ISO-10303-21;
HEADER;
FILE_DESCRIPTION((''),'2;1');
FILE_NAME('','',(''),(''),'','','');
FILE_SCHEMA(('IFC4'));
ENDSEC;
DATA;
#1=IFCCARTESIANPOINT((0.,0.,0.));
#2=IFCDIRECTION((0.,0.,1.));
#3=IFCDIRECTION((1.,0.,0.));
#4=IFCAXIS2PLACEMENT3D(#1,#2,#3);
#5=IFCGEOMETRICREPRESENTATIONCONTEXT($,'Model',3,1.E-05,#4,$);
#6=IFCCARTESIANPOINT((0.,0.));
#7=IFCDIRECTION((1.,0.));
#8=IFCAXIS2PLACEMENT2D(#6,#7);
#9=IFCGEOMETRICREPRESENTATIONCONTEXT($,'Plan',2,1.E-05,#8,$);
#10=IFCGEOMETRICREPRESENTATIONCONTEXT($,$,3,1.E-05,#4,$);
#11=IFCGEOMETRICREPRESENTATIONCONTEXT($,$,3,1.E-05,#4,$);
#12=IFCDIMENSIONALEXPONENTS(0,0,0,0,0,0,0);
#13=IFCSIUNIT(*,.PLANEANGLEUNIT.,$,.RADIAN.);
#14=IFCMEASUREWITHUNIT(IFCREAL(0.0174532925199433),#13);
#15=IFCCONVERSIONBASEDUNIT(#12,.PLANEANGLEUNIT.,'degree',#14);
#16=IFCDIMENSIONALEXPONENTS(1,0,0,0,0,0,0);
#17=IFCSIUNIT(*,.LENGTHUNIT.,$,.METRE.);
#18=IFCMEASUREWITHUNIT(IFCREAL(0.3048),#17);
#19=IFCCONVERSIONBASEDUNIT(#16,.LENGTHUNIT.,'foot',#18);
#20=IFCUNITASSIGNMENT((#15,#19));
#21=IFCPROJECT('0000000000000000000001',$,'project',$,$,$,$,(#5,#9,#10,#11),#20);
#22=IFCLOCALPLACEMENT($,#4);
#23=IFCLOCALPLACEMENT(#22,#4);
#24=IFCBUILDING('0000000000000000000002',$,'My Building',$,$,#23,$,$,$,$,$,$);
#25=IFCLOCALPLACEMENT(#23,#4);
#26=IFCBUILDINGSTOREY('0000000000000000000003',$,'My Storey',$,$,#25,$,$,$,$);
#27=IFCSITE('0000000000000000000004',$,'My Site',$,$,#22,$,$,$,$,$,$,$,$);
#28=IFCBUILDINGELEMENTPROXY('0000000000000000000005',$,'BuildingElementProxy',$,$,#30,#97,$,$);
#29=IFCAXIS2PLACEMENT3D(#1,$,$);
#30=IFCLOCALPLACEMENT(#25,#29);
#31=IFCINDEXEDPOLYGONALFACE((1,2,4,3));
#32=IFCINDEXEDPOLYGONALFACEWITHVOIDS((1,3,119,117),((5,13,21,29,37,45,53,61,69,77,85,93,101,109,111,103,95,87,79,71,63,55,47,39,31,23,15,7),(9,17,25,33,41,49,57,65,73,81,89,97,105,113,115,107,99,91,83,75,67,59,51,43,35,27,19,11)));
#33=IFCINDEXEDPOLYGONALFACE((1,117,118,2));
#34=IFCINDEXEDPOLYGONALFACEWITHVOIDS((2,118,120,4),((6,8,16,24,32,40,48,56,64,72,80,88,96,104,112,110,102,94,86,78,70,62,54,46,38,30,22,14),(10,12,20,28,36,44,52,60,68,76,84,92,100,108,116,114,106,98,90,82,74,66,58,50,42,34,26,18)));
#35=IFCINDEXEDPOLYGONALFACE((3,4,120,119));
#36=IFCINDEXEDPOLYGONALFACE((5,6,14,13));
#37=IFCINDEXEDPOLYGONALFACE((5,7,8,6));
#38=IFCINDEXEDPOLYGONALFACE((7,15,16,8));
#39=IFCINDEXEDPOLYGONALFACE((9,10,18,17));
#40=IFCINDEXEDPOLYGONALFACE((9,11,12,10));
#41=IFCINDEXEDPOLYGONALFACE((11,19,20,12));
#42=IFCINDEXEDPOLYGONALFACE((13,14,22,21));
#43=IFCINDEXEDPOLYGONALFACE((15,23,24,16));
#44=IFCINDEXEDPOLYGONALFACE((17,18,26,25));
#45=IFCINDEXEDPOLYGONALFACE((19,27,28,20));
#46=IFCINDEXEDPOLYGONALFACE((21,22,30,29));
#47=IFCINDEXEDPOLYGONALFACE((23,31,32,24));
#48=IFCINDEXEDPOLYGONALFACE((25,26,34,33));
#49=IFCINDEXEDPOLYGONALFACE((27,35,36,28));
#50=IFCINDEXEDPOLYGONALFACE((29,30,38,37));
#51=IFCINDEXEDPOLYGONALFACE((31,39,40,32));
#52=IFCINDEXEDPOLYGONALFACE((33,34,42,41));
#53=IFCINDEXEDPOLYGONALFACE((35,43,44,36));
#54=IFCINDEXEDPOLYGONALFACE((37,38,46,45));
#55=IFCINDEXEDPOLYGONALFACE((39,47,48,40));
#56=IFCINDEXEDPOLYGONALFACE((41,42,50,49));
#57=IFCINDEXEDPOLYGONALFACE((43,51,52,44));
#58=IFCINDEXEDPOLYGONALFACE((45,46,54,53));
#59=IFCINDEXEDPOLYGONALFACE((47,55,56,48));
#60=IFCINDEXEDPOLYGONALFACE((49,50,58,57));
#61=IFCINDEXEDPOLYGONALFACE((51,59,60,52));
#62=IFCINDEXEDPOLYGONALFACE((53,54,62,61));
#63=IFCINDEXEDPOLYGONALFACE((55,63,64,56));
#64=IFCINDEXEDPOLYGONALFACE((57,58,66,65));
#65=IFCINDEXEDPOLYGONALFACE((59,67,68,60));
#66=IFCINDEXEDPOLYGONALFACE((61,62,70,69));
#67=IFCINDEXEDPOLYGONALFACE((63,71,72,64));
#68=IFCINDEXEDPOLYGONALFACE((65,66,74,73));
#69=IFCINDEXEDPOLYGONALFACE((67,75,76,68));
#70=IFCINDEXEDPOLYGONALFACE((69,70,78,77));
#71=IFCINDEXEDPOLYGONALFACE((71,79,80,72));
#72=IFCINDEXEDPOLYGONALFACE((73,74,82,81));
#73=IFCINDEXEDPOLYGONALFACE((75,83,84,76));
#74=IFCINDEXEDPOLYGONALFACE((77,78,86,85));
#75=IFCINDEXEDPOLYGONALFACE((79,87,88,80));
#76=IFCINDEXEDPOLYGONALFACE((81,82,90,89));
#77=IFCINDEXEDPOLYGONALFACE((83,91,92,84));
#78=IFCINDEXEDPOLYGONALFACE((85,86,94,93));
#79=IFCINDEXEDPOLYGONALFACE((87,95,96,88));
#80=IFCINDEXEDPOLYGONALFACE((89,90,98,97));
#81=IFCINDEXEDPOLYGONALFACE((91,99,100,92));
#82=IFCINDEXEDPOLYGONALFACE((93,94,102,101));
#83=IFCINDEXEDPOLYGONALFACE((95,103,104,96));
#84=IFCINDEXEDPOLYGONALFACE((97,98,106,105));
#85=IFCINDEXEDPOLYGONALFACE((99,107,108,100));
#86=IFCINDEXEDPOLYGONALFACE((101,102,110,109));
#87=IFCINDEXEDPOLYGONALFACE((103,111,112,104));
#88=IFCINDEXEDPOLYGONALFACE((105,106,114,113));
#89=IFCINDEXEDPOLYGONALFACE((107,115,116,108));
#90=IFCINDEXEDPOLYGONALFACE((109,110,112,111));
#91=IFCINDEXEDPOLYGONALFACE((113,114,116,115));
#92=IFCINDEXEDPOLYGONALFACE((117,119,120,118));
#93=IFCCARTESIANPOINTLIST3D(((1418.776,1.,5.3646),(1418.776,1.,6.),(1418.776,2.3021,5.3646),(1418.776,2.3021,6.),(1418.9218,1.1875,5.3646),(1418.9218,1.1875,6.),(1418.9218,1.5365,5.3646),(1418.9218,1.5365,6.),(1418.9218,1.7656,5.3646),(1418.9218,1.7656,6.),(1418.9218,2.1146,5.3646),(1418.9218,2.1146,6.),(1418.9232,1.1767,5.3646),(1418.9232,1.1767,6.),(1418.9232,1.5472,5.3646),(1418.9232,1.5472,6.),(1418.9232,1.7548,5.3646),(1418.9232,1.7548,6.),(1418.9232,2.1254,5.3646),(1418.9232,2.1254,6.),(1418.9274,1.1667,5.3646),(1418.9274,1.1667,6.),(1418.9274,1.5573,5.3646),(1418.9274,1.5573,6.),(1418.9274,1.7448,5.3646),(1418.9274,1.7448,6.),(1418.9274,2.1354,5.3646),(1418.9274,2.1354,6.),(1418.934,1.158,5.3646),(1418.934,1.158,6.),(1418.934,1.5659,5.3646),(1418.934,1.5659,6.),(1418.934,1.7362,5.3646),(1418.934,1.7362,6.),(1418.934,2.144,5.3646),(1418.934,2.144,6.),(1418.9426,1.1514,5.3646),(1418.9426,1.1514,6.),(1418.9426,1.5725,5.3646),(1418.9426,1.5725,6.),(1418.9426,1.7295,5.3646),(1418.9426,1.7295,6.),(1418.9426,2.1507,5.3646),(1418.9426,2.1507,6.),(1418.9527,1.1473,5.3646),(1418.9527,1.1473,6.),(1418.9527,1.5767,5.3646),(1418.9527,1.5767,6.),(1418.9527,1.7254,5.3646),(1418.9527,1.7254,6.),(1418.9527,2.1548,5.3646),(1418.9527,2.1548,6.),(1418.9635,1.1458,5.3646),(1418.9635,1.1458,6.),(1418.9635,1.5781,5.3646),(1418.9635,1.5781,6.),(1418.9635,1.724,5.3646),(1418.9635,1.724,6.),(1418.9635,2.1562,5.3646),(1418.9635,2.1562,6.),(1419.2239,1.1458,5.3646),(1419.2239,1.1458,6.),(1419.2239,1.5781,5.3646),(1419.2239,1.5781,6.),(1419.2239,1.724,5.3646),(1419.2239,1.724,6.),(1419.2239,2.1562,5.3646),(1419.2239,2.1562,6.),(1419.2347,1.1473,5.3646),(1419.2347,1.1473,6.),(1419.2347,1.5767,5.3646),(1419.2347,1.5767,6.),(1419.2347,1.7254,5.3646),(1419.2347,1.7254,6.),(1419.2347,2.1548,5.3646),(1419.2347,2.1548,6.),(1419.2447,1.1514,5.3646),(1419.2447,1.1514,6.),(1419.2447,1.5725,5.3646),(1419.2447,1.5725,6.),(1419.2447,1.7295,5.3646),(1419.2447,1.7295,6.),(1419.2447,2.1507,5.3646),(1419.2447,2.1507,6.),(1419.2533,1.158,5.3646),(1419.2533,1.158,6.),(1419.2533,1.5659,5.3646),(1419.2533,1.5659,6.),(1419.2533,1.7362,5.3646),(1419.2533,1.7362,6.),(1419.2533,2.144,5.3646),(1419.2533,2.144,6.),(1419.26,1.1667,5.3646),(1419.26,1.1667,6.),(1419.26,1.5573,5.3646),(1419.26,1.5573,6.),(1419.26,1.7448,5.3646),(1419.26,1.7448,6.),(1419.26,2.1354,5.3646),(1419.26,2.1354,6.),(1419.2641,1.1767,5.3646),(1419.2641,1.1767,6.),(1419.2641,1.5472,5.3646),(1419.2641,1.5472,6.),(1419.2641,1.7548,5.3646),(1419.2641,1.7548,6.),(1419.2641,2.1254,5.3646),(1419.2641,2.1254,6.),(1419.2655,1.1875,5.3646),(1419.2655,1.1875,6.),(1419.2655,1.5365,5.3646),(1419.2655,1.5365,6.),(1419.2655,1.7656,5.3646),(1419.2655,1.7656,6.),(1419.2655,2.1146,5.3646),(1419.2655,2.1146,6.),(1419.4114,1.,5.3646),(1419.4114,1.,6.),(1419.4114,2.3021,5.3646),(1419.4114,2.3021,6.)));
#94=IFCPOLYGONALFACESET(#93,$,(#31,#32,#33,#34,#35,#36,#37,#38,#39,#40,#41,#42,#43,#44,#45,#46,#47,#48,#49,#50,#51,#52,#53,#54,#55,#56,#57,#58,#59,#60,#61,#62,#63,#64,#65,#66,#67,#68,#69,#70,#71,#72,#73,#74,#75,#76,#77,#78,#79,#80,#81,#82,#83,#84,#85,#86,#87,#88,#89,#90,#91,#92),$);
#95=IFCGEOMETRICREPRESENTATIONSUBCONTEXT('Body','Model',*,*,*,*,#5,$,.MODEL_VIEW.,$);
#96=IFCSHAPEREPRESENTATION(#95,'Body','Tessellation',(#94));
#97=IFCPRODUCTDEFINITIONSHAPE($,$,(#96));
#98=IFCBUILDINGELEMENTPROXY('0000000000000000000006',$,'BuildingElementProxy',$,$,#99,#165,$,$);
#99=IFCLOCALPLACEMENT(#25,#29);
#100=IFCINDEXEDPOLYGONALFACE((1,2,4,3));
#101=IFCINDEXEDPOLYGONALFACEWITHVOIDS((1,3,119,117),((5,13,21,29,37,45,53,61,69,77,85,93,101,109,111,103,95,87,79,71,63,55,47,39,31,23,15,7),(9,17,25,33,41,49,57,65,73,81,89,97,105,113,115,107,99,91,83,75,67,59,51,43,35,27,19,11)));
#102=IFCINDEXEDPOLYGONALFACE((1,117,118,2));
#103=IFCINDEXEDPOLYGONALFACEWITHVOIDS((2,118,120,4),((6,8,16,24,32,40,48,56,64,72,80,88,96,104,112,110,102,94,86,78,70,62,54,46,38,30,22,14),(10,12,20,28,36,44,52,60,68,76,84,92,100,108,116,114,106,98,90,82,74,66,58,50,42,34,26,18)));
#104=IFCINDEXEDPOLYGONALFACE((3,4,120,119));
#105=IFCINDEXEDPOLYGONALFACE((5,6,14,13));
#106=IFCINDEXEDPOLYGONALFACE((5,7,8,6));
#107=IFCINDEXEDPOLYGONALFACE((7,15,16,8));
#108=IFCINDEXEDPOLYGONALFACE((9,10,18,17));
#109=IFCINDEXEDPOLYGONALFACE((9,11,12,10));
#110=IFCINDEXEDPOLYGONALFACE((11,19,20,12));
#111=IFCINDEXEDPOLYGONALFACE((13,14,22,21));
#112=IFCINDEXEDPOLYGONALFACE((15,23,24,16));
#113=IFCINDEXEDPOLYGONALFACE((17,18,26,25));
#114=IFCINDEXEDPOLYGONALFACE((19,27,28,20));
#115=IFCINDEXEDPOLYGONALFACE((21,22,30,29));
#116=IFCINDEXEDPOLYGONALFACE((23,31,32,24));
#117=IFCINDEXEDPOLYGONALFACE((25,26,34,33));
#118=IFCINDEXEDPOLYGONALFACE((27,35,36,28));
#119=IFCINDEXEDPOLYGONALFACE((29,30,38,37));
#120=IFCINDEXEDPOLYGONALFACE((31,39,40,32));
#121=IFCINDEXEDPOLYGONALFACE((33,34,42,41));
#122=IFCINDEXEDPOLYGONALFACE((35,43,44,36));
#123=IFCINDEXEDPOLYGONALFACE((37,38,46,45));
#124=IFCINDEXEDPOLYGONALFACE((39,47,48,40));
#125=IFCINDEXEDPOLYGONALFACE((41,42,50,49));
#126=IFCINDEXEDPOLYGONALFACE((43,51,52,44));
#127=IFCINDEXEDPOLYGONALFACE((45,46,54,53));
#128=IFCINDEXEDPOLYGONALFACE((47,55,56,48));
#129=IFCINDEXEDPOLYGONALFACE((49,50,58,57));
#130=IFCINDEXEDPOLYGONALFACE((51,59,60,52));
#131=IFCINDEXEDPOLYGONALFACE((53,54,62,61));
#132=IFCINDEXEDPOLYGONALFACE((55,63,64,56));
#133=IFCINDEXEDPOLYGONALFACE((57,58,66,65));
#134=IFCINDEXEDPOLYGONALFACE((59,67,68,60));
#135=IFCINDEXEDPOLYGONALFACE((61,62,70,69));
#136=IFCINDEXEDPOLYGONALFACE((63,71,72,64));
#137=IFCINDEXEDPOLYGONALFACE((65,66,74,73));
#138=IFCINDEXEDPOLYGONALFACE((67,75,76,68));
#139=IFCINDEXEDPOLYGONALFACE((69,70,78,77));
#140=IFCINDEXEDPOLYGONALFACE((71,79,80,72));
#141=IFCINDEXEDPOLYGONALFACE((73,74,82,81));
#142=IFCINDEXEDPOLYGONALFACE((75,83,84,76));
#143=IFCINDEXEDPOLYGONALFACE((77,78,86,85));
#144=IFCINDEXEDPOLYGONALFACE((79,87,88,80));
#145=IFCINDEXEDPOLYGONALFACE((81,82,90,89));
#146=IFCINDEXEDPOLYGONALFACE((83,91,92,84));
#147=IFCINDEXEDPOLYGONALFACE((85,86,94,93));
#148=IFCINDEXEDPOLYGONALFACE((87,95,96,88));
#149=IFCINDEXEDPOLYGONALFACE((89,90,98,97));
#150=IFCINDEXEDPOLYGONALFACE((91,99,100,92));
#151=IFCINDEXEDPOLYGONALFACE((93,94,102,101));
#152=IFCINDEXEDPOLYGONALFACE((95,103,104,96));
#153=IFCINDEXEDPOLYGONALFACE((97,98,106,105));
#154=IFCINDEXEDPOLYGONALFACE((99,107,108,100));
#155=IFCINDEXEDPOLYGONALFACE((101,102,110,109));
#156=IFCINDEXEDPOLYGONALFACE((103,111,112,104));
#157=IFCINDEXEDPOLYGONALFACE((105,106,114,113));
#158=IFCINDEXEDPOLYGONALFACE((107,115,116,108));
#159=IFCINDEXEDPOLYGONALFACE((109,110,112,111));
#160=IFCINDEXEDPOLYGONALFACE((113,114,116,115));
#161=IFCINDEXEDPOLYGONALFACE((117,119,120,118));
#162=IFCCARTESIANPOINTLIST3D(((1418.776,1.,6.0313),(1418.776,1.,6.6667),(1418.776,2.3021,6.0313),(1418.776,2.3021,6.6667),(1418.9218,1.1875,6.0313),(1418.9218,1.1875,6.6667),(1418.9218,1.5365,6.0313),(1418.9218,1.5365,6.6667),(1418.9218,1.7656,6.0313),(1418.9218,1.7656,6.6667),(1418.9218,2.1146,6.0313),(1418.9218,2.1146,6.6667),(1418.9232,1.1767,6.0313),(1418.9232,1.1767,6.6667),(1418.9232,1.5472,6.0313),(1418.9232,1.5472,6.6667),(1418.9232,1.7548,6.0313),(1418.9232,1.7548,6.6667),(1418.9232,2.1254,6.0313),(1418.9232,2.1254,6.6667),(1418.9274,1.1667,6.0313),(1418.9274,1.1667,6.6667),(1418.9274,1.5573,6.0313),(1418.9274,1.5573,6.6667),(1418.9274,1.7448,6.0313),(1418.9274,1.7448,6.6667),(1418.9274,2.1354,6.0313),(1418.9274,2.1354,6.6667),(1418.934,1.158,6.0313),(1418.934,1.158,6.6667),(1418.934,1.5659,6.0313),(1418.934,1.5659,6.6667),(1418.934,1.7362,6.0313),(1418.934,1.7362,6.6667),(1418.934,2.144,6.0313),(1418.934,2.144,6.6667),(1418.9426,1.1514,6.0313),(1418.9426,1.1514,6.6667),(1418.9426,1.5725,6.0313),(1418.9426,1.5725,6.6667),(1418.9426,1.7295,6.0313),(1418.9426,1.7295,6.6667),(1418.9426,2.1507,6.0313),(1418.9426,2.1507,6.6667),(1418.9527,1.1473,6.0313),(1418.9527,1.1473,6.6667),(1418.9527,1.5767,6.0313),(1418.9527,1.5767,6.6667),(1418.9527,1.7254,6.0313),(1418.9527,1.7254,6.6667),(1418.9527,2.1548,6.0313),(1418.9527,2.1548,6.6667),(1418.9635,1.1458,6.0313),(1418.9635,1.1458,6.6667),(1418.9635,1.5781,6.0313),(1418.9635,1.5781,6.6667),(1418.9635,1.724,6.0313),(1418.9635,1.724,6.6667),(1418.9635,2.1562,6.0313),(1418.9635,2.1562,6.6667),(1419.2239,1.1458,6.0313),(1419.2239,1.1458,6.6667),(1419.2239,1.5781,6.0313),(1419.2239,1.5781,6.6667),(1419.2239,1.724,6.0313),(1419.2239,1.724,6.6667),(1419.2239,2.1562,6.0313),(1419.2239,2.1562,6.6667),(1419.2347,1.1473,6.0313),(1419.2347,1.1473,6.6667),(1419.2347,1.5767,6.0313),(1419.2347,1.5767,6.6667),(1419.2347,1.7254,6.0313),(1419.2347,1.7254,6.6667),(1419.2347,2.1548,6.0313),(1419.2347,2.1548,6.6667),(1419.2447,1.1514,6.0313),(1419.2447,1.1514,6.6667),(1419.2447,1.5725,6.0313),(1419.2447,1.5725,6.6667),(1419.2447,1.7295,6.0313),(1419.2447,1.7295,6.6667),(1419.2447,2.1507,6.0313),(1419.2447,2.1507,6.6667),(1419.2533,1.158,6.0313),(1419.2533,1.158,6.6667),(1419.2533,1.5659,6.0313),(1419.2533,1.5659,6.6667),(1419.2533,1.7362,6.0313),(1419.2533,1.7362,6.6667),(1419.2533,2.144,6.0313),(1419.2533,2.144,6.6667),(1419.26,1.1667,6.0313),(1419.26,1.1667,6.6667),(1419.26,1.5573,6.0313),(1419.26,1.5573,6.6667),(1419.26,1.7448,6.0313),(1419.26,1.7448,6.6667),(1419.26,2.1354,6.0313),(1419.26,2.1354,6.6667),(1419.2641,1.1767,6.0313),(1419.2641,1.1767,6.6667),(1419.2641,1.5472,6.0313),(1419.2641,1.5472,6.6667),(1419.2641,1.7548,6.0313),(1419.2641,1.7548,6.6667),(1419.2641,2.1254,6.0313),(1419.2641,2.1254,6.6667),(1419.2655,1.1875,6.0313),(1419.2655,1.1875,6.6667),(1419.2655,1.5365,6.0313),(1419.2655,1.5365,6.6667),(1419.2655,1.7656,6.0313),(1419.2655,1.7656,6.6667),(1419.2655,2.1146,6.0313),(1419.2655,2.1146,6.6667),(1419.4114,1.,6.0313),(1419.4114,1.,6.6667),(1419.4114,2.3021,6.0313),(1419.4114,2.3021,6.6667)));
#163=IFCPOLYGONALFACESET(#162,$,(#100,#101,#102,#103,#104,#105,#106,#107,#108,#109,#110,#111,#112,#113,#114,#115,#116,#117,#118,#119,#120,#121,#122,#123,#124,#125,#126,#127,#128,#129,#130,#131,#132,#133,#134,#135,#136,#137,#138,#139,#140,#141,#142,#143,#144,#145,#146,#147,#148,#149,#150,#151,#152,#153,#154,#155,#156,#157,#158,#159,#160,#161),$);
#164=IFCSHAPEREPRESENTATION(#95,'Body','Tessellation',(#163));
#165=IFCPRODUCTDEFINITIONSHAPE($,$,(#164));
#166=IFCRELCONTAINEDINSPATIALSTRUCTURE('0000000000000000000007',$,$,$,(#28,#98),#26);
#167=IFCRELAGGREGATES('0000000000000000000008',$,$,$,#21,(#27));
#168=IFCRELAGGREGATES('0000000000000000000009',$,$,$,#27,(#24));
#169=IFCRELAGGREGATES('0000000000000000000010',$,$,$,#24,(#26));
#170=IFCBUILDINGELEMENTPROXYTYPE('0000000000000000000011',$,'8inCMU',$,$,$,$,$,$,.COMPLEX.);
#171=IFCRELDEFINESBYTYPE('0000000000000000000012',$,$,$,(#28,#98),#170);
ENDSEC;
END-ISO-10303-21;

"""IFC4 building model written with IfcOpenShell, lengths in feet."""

from ifc_helpers import new_model, entity, si_unit, converted_unit, frame, origin_with_axes, origin_2d_with_axis, place, context, subcontext, project, spatial, line, indexed_curve, outline, extrude, source, transform, mapped, type_object, type_shapes, element, save


model = new_model("IFC4")

# Units and contexts
model_context_1 = context("Model", 3, precision=1e-05, world=origin_with_axes())
plan_context = context("Plan", 2, precision=1e-05, world=origin_2d_with_axis())
context_of_model_1 = context(None, 3, precision=1e-05, world=origin_with_axes())
context_of_model_2 = context(None, 3, precision=1e-05, world=origin_with_axes())
body_context_1 = subcontext(model_context_1, "Body", "Model", "MODEL_VIEW")
ifc_project = project(units=[converted_unit("PLANEANGLEUNIT", "degree", entity("IfcReal", 0.0174532925199433), si_unit("PLANEANGLEUNIT", "RADIAN"), dimensions=[0, 0, 0, 0, 0, 0, 0]), converted_unit("LENGTHUNIT", "foot", entity("IfcReal", 0.3048), si_unit("LENGTHUNIT", "METRE"), dimensions=[1, 0, 0, 0, 0, 0, 0])], contexts=[model_context_1, plan_context, context_of_model_1, context_of_model_2])

# Site, building, storey
site_placement = place(None, origin_with_axes())
site = spatial("IfcSite", under=ifc_project, at=site_placement, Name="My Site")
building_placement = place(site_placement, origin_with_axes())
building = spatial("IfcBuilding", under=site, at=building_placement, Name="My Building")
storey_placement = place(building_placement, origin_with_axes())
storey = spatial("IfcBuildingStorey", under=building, at=storey_placement, Name="My Storey")

# Building element proxies
building_element_proxy_type_1 = type_object("IfcBuildingElementProxyType", Name="8inCMU", PredefinedType="COMPLEX")
shared_shape_1 = source(origin_with_axes(), body_context_1, "Body", "SweptSolid", [
    extrude(outline(indexed_curve([(-0.3177, -0.651), (0.3177, -0.651), (0.3177, 0.651), (-0.3177, 0.651), (0.1719, -0.1146), (0.1719, -0.4635), (0.1705, -0.4743), (0.1663, -0.4844), (0.1597, -0.493), (0.151, -0.4996), (0.141, -0.5038), (0.1302, -0.5052), (-0.1302, -0.5052), (-0.141, -0.5038), (-0.151, -0.4996), (-0.1597, -0.493), (-0.1663, -0.4844), (-0.1705, -0.4743), (-0.1719, -0.4635), (-0.1719, -0.1146), (-0.1705, -0.1038), (-0.1663, -0.0938), (-0.1597, -0.0851), (-0.151, -0.0785), (-0.141, -0.0743), (-0.1302, -0.0729), (0.1302, -0.0729), (0.141, -0.0743), (0.151, -0.0785), (0.1597, -0.0851), (0.1663, -0.0938), (0.1705, -0.1038), (0.151, 0.0785), (0.141, 0.0743), (0.1302, 0.0729), (-0.1302, 0.0729), (-0.141, 0.0743), (-0.151, 0.0785), (-0.1597, 0.0851), (-0.1663, 0.0937), (-0.1705, 0.1038), (-0.1719, 0.1146), (-0.1719, 0.4635), (-0.1705, 0.4743), (-0.1663, 0.4844), (-0.1597, 0.493), (-0.151, 0.4996), (-0.141, 0.5038), (-0.1302, 0.5052), (0.1302, 0.5052), (0.141, 0.5038), (0.151, 0.4996), (0.1597, 0.493), (0.1663, 0.4844), (0.1705, 0.4743), (0.1719, 0.4635), (0.1719, 0.1146), (0.1705, 0.1038), (0.1663, 0.0937), (0.1597, 0.0851)], segments=[line(4, 3), line(3, 2), line(2, 1), line(1, 4)], self_intersect=False), holes=[indexed_curve([(-0.3177, -0.651), (0.3177, -0.651), (0.3177, 0.651), (-0.3177, 0.651), (0.1719, -0.1146), (0.1719, -0.4635), (0.1705, -0.4743), (0.1663, -0.4844), (0.1597, -0.493), (0.151, -0.4996), (0.141, -0.5038), (0.1302, -0.5052), (-0.1302, -0.5052), (-0.141, -0.5038), (-0.151, -0.4996), (-0.1597, -0.493), (-0.1663, -0.4844), (-0.1705, -0.4743), (-0.1719, -0.4635), (-0.1719, -0.1146), (-0.1705, -0.1038), (-0.1663, -0.0938), (-0.1597, -0.0851), (-0.151, -0.0785), (-0.141, -0.0743), (-0.1302, -0.0729), (0.1302, -0.0729), (0.141, -0.0743), (0.151, -0.0785), (0.1597, -0.0851), (0.1663, -0.0938), (0.1705, -0.1038), (0.151, 0.0785), (0.141, 0.0743), (0.1302, 0.0729), (-0.1302, 0.0729), (-0.141, 0.0743), (-0.151, 0.0785), (-0.1597, 0.0851), (-0.1663, 0.0937), (-0.1705, 0.1038), (-0.1719, 0.1146), (-0.1719, 0.4635), (-0.1705, 0.4743), (-0.1663, 0.4844), (-0.1597, 0.493), (-0.151, 0.4996), (-0.141, 0.5038), (-0.1302, 0.5052), (0.1302, 0.5052), (0.141, 0.5038), (0.151, 0.4996), (0.1597, 0.493), (0.1663, 0.4844), (0.1705, 0.4743), (0.1719, 0.4635), (0.1719, 0.1146), (0.1705, 0.1038), (0.1663, 0.0937), (0.1597, 0.0851)], segments=[line(20, 19), line(19, 18), line(18, 17), line(17, 16), line(16, 15), line(15, 14), line(14, 13), line(13, 12), line(12, 11), line(11, 10), line(10, 9), line(9, 8), line(8, 7), line(7, 6), line(6, 5), line(5, 32), line(32, 31), line(31, 30), line(30, 29), line(29, 28), line(28, 27), line(27, 26), line(26, 25), line(25, 24), line(24, 23), line(23, 22), line(22, 21), line(21, 20)], self_intersect=False), indexed_curve([(-0.3177, -0.651), (0.3177, -0.651), (0.3177, 0.651), (-0.3177, 0.651), (0.1719, -0.1146), (0.1719, -0.4635), (0.1705, -0.4743), (0.1663, -0.4844), (0.1597, -0.493), (0.151, -0.4996), (0.141, -0.5038), (0.1302, -0.5052), (-0.1302, -0.5052), (-0.141, -0.5038), (-0.151, -0.4996), (-0.1597, -0.493), (-0.1663, -0.4844), (-0.1705, -0.4743), (-0.1719, -0.4635), (-0.1719, -0.1146), (-0.1705, -0.1038), (-0.1663, -0.0938), (-0.1597, -0.0851), (-0.151, -0.0785), (-0.141, -0.0743), (-0.1302, -0.0729), (0.1302, -0.0729), (0.141, -0.0743), (0.151, -0.0785), (0.1597, -0.0851), (0.1663, -0.0938), (0.1705, -0.1038), (0.151, 0.0785), (0.141, 0.0743), (0.1302, 0.0729), (-0.1302, 0.0729), (-0.141, 0.0743), (-0.151, 0.0785), (-0.1597, 0.0851), (-0.1663, 0.0937), (-0.1705, 0.1038), (-0.1719, 0.1146), (-0.1719, 0.4635), (-0.1705, 0.4743), (-0.1663, 0.4844), (-0.1597, 0.493), (-0.151, 0.4996), (-0.141, 0.5038), (-0.1302, 0.5052), (0.1302, 0.5052), (0.141, 0.5038), (0.151, 0.4996), (0.1597, 0.493), (0.1663, 0.4844), (0.1705, 0.4743), (0.1719, 0.4635), (0.1719, 0.1146), (0.1705, 0.1038), (0.1663, 0.0937), (0.1597, 0.0851)], segments=[line(44, 43), line(43, 42), line(42, 41), line(41, 40), line(40, 39), line(39, 38), line(38, 37), line(37, 36), line(36, 35), line(35, 34), line(34, 33), line(33, 60), line(60, 59), line(59, 58), line(58, 57), line(57, 56), line(56, 55), line(55, 54), line(54, 53), line(53, 52), line(52, 51), line(51, 50), line(50, 49), line(49, 48), line(48, 47), line(47, 46), line(46, 45), line(45, 44)], self_intersect=False)]), frame((-0.651, 0.0, 0.0), z_axis=(0.0, 0.0, 1.0), x_axis=(0.0, -1.0, 0.0)), (0.0, 0.0, 1.0), 0.6354),
])
type_shapes(building_element_proxy_type_1, [shared_shape_1])
for number, where, z_axis, x_axis, name in (
    (1, (1419.0936, 2.3021, 5.3646), (0.0, 0.0, 1.0), (0.0, 1.0, 0.0), "BuildingElementProxy"),
    (2, (1419.0936, 2.3021, 6.0313), (0.0, 0.0, 1.0), (0.0, 1.0, 0.0), "BuildingElementProxy"),
):
    element("IfcBuildingElementProxy", number, at=place(storey_placement, frame(where, z_axis=z_axis, x_axis=x_axis)), inside=storey, type_object=building_element_proxy_type_1, Name=name, context=body_context_1, shape_type="MappedRepresentation", body=[
        mapped(shared_shape_1, transform((0.0, 0.0, 0.0), x_axis=(1.0, 0.0, 0.0), y_axis=(0.0, 1.0, 0.0), z_axis=(0.0, 0.0, 1.0), scale=1.0)),
    ])

save(model, "model.ifc")
